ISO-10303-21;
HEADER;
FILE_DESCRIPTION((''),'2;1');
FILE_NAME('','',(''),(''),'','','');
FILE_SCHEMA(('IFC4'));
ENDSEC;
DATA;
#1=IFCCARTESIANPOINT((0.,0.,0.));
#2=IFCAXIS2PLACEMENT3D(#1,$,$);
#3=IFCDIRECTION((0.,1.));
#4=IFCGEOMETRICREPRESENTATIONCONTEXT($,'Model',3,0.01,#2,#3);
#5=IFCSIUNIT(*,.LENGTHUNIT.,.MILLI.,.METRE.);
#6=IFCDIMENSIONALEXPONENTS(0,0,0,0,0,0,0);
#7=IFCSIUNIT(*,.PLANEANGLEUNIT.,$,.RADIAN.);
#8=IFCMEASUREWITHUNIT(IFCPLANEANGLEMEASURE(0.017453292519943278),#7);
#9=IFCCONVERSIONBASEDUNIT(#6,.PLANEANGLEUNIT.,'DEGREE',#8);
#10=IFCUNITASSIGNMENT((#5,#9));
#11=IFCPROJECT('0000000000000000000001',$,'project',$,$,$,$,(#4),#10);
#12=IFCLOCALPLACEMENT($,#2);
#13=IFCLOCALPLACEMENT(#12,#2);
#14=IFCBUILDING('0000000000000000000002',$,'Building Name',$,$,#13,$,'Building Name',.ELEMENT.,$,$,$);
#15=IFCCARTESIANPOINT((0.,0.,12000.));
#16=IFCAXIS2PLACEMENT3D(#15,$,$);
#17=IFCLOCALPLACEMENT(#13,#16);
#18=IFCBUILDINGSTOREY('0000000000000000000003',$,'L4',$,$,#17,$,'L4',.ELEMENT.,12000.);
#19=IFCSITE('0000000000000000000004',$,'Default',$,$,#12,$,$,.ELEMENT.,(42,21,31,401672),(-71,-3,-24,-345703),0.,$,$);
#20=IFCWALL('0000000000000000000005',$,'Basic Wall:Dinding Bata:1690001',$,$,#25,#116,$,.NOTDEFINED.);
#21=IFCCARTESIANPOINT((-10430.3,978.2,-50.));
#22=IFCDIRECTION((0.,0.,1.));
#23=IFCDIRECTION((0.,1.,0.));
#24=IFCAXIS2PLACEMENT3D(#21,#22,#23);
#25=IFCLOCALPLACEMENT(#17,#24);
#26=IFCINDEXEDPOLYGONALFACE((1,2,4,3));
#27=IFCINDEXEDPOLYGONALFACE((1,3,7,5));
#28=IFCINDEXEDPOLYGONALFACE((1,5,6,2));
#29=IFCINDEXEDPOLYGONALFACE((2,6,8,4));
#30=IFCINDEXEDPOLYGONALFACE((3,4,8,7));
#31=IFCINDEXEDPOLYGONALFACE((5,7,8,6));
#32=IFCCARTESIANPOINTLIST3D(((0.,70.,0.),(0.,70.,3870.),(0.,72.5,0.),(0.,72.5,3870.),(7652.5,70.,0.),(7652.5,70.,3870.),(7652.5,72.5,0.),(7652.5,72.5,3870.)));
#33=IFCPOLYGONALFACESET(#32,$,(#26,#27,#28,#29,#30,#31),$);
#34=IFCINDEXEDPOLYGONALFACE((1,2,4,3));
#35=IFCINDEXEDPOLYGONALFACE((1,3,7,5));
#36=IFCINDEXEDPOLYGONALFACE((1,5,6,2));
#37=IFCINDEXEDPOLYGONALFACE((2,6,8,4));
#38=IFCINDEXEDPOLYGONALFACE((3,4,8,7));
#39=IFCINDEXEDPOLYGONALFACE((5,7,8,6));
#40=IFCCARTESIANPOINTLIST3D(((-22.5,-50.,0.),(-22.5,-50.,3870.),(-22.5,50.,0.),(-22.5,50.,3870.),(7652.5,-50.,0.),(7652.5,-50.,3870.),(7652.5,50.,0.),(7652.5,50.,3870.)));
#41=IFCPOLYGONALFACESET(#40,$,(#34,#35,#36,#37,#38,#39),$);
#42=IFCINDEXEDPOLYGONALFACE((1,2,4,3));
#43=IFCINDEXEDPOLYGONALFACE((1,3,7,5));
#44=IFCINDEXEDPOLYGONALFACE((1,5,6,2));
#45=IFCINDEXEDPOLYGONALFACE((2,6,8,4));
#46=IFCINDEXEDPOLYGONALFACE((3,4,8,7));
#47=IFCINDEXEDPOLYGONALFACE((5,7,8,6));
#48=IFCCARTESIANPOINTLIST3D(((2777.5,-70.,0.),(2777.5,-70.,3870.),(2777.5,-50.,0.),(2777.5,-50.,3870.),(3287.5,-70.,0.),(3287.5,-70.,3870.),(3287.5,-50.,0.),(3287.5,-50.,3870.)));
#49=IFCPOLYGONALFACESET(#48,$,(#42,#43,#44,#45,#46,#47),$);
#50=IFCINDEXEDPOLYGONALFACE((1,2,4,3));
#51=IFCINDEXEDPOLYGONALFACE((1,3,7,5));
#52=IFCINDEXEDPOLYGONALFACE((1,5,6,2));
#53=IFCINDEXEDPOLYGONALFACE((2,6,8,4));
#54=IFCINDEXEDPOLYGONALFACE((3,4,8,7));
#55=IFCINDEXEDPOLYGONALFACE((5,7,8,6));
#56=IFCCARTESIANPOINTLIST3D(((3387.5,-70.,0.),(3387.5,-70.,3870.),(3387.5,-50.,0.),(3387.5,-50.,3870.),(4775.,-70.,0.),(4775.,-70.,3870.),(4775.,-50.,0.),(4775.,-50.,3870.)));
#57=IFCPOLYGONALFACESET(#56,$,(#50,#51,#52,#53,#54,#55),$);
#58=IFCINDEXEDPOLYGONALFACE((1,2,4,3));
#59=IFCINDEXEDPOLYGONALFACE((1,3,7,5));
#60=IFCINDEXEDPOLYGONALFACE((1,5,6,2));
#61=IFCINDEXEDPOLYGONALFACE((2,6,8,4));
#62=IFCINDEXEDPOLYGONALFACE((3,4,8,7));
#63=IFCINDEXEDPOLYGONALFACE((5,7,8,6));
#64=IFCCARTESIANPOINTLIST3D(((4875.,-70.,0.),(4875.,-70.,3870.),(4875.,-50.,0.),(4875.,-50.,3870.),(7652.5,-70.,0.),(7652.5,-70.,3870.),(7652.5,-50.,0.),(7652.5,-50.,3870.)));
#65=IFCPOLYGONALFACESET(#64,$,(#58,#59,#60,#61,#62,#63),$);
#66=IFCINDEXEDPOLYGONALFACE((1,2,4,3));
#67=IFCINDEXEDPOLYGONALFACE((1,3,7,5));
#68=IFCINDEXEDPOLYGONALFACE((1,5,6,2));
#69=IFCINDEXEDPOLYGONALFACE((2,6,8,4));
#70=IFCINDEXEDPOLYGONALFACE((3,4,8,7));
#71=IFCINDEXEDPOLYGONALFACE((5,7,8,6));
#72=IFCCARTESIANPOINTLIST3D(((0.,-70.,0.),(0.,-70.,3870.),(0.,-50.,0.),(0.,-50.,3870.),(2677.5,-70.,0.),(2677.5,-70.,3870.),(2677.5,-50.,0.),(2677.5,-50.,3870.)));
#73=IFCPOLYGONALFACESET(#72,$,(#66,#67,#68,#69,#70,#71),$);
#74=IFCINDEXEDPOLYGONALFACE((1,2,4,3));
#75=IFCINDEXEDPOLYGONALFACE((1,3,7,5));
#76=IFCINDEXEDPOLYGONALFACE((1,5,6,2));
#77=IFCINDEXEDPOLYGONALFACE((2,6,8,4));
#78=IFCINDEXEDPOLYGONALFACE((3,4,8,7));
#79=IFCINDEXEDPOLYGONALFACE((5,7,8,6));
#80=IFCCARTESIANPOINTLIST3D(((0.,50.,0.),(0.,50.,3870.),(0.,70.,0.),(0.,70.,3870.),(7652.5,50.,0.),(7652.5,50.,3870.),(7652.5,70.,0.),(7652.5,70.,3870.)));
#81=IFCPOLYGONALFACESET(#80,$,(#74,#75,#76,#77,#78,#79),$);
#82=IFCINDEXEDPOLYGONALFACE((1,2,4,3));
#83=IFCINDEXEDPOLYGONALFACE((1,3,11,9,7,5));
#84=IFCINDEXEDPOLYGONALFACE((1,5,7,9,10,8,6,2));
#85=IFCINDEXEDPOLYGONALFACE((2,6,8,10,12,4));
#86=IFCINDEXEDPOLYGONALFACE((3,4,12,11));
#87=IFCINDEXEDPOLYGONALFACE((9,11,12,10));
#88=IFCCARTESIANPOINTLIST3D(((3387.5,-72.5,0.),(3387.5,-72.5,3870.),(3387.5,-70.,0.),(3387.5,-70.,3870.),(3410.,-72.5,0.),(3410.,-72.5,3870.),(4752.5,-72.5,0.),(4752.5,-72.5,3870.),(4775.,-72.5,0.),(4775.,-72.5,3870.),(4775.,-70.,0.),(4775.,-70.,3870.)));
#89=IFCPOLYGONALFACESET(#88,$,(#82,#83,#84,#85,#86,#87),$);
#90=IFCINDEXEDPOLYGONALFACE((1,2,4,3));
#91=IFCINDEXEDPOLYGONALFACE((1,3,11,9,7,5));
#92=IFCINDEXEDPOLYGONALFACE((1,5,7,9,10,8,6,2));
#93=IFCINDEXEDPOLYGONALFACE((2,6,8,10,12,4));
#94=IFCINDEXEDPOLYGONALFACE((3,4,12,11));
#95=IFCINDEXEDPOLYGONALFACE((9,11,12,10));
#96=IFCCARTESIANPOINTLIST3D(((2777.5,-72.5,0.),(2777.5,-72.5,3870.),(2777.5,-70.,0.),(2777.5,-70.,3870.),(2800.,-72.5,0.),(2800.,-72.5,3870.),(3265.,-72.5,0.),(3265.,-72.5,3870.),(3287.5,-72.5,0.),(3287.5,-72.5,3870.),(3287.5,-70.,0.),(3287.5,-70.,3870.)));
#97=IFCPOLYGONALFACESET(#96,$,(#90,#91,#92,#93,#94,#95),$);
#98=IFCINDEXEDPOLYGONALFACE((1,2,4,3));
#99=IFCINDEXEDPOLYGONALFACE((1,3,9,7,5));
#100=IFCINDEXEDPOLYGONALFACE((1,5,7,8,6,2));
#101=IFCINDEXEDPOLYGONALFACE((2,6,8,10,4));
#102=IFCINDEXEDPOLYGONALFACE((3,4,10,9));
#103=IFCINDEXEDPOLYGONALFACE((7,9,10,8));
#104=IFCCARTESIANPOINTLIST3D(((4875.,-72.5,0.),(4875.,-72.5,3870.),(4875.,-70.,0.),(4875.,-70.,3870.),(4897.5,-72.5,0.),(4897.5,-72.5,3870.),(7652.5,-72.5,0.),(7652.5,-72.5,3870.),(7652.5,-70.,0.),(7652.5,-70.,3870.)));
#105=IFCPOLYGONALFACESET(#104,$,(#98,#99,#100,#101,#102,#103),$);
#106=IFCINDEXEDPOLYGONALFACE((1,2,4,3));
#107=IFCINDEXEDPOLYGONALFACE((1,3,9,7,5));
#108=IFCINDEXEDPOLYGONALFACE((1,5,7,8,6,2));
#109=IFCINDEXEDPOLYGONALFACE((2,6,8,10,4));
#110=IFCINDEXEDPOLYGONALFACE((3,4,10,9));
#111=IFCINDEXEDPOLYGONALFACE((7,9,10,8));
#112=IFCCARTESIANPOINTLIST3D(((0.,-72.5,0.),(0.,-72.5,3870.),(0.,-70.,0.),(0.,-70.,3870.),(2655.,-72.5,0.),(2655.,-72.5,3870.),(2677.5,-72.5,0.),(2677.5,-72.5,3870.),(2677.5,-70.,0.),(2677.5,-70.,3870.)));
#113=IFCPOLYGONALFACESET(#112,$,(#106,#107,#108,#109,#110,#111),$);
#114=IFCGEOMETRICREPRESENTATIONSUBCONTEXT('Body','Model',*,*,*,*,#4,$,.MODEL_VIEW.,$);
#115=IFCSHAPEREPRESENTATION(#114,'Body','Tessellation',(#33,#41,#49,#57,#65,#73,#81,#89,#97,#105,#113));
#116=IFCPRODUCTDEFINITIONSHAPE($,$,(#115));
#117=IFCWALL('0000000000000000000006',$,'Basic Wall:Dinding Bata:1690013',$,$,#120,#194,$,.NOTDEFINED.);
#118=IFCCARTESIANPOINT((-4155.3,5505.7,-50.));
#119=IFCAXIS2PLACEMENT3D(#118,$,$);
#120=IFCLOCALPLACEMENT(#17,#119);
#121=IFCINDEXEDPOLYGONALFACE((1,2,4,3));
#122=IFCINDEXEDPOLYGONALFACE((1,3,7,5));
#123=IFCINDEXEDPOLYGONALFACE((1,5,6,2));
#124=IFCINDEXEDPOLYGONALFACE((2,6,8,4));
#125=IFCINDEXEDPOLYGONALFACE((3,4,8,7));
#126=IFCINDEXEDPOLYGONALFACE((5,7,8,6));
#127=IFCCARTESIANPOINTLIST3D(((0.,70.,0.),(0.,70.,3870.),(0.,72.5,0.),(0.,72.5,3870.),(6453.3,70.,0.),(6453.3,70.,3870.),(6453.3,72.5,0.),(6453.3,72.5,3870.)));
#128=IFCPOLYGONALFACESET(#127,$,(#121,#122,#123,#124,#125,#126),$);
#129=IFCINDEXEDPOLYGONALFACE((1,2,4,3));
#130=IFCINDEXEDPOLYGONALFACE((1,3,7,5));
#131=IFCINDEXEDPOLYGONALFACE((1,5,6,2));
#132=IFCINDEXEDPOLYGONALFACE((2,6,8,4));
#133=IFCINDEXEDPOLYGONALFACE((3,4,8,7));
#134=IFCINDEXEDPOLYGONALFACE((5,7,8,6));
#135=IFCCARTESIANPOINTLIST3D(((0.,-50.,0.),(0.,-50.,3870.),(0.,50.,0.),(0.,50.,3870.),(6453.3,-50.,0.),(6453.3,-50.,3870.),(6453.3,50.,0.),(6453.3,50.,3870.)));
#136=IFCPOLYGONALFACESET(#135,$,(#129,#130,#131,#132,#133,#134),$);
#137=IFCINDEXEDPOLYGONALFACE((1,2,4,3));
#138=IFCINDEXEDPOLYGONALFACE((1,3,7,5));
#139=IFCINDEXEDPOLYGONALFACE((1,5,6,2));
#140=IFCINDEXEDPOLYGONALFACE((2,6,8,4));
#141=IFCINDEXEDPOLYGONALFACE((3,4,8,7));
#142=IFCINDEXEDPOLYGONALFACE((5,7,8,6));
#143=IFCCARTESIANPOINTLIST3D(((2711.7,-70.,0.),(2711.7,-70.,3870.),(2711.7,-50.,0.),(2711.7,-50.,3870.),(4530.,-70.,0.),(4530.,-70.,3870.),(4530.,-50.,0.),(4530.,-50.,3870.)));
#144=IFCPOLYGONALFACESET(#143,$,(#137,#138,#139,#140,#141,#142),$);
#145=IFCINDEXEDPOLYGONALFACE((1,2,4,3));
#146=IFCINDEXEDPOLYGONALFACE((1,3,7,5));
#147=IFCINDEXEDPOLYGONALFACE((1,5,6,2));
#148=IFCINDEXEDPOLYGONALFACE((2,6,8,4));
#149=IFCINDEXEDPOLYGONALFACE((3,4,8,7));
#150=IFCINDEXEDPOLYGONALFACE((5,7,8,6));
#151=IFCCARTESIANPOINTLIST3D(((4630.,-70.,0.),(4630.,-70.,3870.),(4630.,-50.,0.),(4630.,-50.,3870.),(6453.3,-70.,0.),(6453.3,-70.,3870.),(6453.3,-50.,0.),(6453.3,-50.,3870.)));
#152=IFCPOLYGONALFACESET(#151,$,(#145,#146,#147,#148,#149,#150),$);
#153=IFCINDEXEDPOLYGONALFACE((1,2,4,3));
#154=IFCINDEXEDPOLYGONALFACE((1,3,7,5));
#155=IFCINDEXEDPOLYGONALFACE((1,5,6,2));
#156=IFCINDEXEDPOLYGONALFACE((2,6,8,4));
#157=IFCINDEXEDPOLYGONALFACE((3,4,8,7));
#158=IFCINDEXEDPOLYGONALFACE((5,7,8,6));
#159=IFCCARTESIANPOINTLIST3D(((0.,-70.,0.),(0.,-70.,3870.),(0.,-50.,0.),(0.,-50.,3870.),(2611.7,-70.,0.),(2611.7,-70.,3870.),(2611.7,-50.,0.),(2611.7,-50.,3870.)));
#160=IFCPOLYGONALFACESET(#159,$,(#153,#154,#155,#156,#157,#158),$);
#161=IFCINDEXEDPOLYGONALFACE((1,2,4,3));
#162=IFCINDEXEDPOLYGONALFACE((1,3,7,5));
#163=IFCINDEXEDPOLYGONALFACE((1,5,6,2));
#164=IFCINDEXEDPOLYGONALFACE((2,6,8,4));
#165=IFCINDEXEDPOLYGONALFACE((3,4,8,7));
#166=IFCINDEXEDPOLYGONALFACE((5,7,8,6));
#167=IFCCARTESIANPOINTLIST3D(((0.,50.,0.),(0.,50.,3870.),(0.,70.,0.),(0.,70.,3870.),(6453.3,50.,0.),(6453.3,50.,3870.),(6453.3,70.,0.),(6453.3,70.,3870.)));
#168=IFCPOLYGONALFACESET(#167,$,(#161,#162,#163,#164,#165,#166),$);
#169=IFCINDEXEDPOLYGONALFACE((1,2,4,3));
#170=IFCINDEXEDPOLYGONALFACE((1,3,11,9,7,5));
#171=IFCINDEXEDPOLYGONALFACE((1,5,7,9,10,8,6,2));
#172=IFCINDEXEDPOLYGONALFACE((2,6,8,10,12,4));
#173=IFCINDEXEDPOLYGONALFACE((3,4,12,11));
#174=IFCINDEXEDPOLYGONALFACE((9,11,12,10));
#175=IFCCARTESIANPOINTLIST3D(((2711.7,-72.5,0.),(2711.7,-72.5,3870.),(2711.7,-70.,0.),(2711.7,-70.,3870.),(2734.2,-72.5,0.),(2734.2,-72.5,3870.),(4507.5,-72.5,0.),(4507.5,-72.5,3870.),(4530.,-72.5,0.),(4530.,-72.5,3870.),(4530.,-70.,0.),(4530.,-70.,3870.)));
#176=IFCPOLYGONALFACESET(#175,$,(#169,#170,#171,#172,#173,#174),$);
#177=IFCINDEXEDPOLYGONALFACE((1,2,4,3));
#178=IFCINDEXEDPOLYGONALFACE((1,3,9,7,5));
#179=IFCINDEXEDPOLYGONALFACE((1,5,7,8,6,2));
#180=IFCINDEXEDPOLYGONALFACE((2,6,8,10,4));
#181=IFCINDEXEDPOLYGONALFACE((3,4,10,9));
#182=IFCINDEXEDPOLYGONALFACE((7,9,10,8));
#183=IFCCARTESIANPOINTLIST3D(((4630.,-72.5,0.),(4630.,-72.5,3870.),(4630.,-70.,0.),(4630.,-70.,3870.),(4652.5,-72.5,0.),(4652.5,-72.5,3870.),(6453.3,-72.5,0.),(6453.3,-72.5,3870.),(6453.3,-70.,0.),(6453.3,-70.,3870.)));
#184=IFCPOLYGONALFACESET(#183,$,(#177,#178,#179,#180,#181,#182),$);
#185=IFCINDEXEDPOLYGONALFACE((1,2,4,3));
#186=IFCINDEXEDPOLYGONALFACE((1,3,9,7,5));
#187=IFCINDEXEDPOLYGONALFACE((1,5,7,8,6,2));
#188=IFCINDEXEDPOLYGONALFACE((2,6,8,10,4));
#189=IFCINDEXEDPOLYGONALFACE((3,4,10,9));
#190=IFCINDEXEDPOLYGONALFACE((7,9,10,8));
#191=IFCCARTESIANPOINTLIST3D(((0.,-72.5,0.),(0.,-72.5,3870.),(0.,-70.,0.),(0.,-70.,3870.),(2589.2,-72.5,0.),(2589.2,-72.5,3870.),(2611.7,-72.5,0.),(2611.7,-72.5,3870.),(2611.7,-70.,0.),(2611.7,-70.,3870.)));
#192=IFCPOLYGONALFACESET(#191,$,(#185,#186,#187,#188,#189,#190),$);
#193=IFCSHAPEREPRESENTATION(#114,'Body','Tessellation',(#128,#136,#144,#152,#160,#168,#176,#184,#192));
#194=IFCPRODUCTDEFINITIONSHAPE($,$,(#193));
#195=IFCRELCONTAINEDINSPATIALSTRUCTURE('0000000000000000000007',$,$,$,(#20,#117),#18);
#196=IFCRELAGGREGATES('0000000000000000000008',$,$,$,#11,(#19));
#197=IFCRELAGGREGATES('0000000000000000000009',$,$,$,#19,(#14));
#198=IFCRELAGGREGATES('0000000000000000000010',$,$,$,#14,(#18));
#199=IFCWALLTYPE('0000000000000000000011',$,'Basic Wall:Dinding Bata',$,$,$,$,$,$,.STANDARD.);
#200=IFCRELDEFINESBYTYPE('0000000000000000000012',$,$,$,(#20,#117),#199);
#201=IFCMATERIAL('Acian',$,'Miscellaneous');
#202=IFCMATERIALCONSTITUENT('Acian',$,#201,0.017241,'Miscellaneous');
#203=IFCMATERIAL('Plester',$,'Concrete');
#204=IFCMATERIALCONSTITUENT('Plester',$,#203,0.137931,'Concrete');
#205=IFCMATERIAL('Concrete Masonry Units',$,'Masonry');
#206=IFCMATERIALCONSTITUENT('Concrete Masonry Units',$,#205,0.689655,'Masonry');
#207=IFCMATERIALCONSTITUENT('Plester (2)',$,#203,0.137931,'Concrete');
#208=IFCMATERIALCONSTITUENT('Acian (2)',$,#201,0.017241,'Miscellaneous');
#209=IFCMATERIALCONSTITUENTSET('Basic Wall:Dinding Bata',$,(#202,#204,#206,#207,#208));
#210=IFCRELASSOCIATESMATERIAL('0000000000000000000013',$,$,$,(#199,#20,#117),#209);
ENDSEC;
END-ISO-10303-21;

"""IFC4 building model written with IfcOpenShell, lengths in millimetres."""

from ifc_helpers import new_model, entity, si_unit, converted_unit, direction, frame, origin, place, context, subcontext, project, spatial, indexed_curve, outline, extrude, material, constituent, constituent_set, type_object, element, save


model = new_model("IFC4")

# Units and contexts
model_context = context("Model", 3, precision=0.01, world=origin(), true_north=direction((0.0, 1.0)))
body_context = subcontext(model_context, "Body", "Model", "MODEL_VIEW")
ifc_project = project(units=[si_unit("LENGTHUNIT", "METRE", prefix="MILLI"), converted_unit("PLANEANGLEUNIT", "DEGREE", entity("IfcPlaneAngleMeasure", 0.017453292519943278), si_unit("PLANEANGLEUNIT", "RADIAN"), dimensions=[0, 0, 0, 0, 0, 0, 0])], contexts=[model_context])

# Site, building, storey
site_placement = place(None, origin())
site = spatial("IfcSite", under=ifc_project, at=site_placement, Name="Default", CompositionType="ELEMENT", RefLatitude=(42, 21, 31, 401672), RefLongitude=(-71, -3, -24, -345703), RefElevation=0.0)
building_placement = place(site_placement, origin())
building = spatial("IfcBuilding", under=site, at=building_placement, Name="Building Name", LongName="Building Name", CompositionType="ELEMENT")
storey_placement = place(building_placement, frame((0.0, 0.0, 12000.0)))
storey = spatial("IfcBuildingStorey", under=building, at=storey_placement, Name="L4", LongName="L4", CompositionType="ELEMENT", Elevation=12000.0)

# Walls
ifc_material_1 = material(Name="Acian", Category="Miscellaneous")
ifc_constituent_1 = constituent(ifc_material_1, Name="Acian", Category="Miscellaneous", fraction=0.017241)
ifc_material_2 = material(Name="Plester", Category="Concrete")
ifc_constituent_2 = constituent(ifc_material_2, Name="Plester", Category="Concrete", fraction=0.137931)
ifc_material_3 = material(Name="Concrete Masonry Units", Category="Masonry")
ifc_constituent_3 = constituent(ifc_material_3, Name="Concrete Masonry Units", Category="Masonry", fraction=0.689655)
ifc_constituent_4 = constituent(ifc_material_2, Name="Plester (2)", Category="Concrete", fraction=0.137931)
ifc_constituent_5 = constituent(ifc_material_1, Name="Acian (2)", Category="Miscellaneous", fraction=0.017241)
ifc_constituent_set = constituent_set(constituents=[ifc_constituent_1, ifc_constituent_2, ifc_constituent_3, ifc_constituent_4, ifc_constituent_5], Name="Basic Wall:Dinding Bata")
wall_type = type_object("IfcWallType", Name="Basic Wall:Dinding Bata", PredefinedType="STANDARD", material=ifc_constituent_set)
wall_1_placement = place(storey_placement, frame((-10430.3, 978.2, -50.0), z_axis=(0.0, 0.0, 1.0), x_axis=(0.0, 1.0, 0.0)))
element("IfcWall", 1, at=wall_1_placement, inside=storey, type_object=wall_type, material=ifc_constituent_set, Name="Basic Wall:Dinding Bata:1690001", PredefinedType="NOTDEFINED", context=body_context, shape_type="SweptSolid", body=[
    extrude(outline(indexed_curve([(-1.3, -3826.2), (1.2, -3826.2), (1.3, 3826.2), (-1.2, 3826.2), (-1.3, -3826.2)], self_intersect=False)), frame((3826.2, 71.2, 0.0), z_axis=(0.0, 0.0, 1.0), x_axis=(0.0, -1.0, 0.0)), (0.0, 0.0, 1.0), 3870.0),
    extrude(outline(indexed_curve([(-3837.5, -50.0), (3837.5, -50.0), (3837.5, 50.0), (-3837.5, 50.0), (-3837.5, -50.0)], self_intersect=False)), frame((3815.0, 0.0, 0.0)), (0.0, 0.0, 1.0), 3870.0),
    extrude(outline(indexed_curve([(-255.0, -10.0), (255.0, -10.0), (255.0, 10.0), (-255.0, 10.0), (-255.0, -10.0)], self_intersect=False)), frame((3032.5, -60.0, 0.0)), (0.0, 0.0, 1.0), 3870.0),
    extrude(outline(indexed_curve([(-693.8, -10.0), (693.8, -10.0), (693.8, 10.0), (-693.8, 10.0), (-693.8, -10.0)], self_intersect=False)), frame((4081.3, -60.0, 0.0)), (0.0, 0.0, 1.0), 3870.0),
    extrude(outline(indexed_curve([(-1388.7, -10.0), (1388.7, -10.0), (1388.7, 10.0), (-1388.7, 10.0), (-1388.7, -10.0)], self_intersect=False)), frame((6263.8, -60.0, 0.0), z_axis=(0.0, 0.0, 1.0), x_axis=(-1.0, 0.0, 0.0)), (0.0, 0.0, 1.0), 3870.0),
    extrude(outline(indexed_curve([(-1338.7, -10.0), (1338.7, -10.0), (1338.7, 10.0), (-1338.7, 10.0), (-1338.7, -10.0)], self_intersect=False)), frame((1338.7, -60.0, 0.0)), (0.0, 0.0, 1.0), 3870.0),
    extrude(outline(indexed_curve([(-3826.2, -10.0), (3826.2, -10.0), (3826.2, 10.0), (-3826.2, 10.0), (-3826.2, -10.0)], self_intersect=False)), frame((3826.2, 60.0, 0.0)), (0.0, 0.0, 1.0), 3870.0),
    extrude(outline(indexed_curve([(671.3, -0.8), (693.8, -0.8), (693.8, 1.7), (-693.8, 1.7), (-693.8, -0.8), (-671.3, -0.8), (671.3, -0.8)], self_intersect=False)), frame((4081.3, -71.7, 0.0)), (0.0, 0.0, 1.0), 3870.0),
    extrude(outline(indexed_curve([(232.5, -0.8), (255.0, -0.8), (255.0, 1.7), (-255.0, 1.7), (-255.0, -0.8), (-232.5, -0.8), (232.5, -0.8)], self_intersect=False)), frame((3032.5, -71.7, 0.0)), (0.0, 0.0, 1.0), 3870.0),
    extrude(outline(indexed_curve([(-1.0, -1662.0), (1.5, -1662.0), (1.5, 1115.5), (-1.0, 1115.5), (-1.0, 1093.0), (-1.0, -1662.0)], self_intersect=False)), frame((5990.5, -71.5, 0.0), z_axis=(0.0, 0.0, 1.0), x_axis=(0.0, 1.0, 0.0)), (0.0, 0.0, 1.0), 3870.0),
    extrude(outline(indexed_curve([(1053.0, -1.0), (1075.5, -1.0), (1075.5, 1.5), (-1602.0, 1.5), (-1602.0, -1.0), (1053.0, -1.0)], self_intersect=False)), frame((1602.0, -71.5, 0.0)), (0.0, 0.0, 1.0), 3870.0),
])
wall_2_placement = place(storey_placement, frame((-4155.3, 5505.7, -50.0)))
element("IfcWall", 2, at=wall_2_placement, inside=storey, type_object=wall_type, material=ifc_constituent_set, Name="Basic Wall:Dinding Bata:1690013", PredefinedType="NOTDEFINED", context=body_context, shape_type="SweptSolid", body=[
    extrude(outline(indexed_curve([(-1.3, -3226.7), (1.2, -3226.7), (1.3, 3226.7), (-1.2, 3226.7), (-1.3, -3226.7)], self_intersect=False)), frame((3226.7, 71.3, 0.0), z_axis=(0.0, 0.0, 1.0), x_axis=(0.0, -1.0, 0.0)), (0.0, 0.0, 1.0), 3870.0),
    extrude(outline(indexed_curve([(-3226.7, -50.0), (3226.7, -50.0), (3226.7, 50.0), (-3226.7, 50.0), (-3226.7, -50.0)], self_intersect=False)), frame((3226.7, 0.0, 0.0)), (0.0, 0.0, 1.0), 3870.0),
    extrude(outline(indexed_curve([(-909.1, -10.0), (909.1, -10.0), (909.1, 10.0), (-909.1, 10.0), (-909.1, -10.0)], self_intersect=False)), frame((3620.9, -60.0, 0.0), z_axis=(0.0, 0.0, 1.0), x_axis=(-1.0, 0.0, 0.0)), (0.0, 0.0, 1.0), 3870.0),
    extrude(outline(indexed_curve([(-911.7, -10.0), (911.7, -10.0), (911.7, 10.0), (-911.7, 10.0), (-911.7, -10.0)], self_intersect=False)), frame((5541.7, -60.0, 0.0), z_axis=(0.0, 0.0, 1.0), x_axis=(-1.0, 0.0, 0.0)), (0.0, 0.0, 1.0), 3870.0),
    extrude(outline(indexed_curve([(-1305.9, -10.0), (1305.9, -10.0), (1305.9, 10.0), (-1305.9, 10.0), (-1305.9, -10.0)], self_intersect=False)), frame((1305.9, -60.0, 0.0)), (0.0, 0.0, 1.0), 3870.0),
    extrude(outline(indexed_curve([(-3226.7, -10.0), (3226.7, -10.0), (3226.7, 10.0), (-3226.7, 10.0), (-3226.7, -10.0)], self_intersect=False)), frame((3226.7, 60.0, 0.0)), (0.0, 0.0, 1.0), 3870.0),
    extrude(outline(indexed_curve([(886.6, -0.8), (909.1, -0.8), (909.1, 1.7), (-909.1, 1.7), (-909.1, -0.8), (-886.6, -0.8), (886.6, -0.8)], self_intersect=False)), frame((3620.9, -71.7, 0.0)), (0.0, 0.0, 1.0), 3870.0),
    extrude(outline(indexed_curve([(-1.0, -1089.5), (1.5, -1089.5), (1.5, 733.8), (-1.0, 733.8), (-1.0, 711.3), (-1.0, -1089.5)], self_intersect=False)), frame((5363.8, -71.5, 0.0), z_axis=(0.0, 0.0, 1.0), x_axis=(0.0, 1.0, 0.0)), (0.0, 0.0, 1.0), 3870.0),
    extrude(outline(indexed_curve([(1026.7, -1.0), (1049.2, -1.0), (1049.2, 1.5), (-1562.5, 1.5), (-1562.5, -1.0), (1026.7, -1.0)], self_intersect=False)), frame((1562.5, -71.5, 0.0)), (0.0, 0.0, 1.0), 3870.0),
])

save(model, "model.ifc")
